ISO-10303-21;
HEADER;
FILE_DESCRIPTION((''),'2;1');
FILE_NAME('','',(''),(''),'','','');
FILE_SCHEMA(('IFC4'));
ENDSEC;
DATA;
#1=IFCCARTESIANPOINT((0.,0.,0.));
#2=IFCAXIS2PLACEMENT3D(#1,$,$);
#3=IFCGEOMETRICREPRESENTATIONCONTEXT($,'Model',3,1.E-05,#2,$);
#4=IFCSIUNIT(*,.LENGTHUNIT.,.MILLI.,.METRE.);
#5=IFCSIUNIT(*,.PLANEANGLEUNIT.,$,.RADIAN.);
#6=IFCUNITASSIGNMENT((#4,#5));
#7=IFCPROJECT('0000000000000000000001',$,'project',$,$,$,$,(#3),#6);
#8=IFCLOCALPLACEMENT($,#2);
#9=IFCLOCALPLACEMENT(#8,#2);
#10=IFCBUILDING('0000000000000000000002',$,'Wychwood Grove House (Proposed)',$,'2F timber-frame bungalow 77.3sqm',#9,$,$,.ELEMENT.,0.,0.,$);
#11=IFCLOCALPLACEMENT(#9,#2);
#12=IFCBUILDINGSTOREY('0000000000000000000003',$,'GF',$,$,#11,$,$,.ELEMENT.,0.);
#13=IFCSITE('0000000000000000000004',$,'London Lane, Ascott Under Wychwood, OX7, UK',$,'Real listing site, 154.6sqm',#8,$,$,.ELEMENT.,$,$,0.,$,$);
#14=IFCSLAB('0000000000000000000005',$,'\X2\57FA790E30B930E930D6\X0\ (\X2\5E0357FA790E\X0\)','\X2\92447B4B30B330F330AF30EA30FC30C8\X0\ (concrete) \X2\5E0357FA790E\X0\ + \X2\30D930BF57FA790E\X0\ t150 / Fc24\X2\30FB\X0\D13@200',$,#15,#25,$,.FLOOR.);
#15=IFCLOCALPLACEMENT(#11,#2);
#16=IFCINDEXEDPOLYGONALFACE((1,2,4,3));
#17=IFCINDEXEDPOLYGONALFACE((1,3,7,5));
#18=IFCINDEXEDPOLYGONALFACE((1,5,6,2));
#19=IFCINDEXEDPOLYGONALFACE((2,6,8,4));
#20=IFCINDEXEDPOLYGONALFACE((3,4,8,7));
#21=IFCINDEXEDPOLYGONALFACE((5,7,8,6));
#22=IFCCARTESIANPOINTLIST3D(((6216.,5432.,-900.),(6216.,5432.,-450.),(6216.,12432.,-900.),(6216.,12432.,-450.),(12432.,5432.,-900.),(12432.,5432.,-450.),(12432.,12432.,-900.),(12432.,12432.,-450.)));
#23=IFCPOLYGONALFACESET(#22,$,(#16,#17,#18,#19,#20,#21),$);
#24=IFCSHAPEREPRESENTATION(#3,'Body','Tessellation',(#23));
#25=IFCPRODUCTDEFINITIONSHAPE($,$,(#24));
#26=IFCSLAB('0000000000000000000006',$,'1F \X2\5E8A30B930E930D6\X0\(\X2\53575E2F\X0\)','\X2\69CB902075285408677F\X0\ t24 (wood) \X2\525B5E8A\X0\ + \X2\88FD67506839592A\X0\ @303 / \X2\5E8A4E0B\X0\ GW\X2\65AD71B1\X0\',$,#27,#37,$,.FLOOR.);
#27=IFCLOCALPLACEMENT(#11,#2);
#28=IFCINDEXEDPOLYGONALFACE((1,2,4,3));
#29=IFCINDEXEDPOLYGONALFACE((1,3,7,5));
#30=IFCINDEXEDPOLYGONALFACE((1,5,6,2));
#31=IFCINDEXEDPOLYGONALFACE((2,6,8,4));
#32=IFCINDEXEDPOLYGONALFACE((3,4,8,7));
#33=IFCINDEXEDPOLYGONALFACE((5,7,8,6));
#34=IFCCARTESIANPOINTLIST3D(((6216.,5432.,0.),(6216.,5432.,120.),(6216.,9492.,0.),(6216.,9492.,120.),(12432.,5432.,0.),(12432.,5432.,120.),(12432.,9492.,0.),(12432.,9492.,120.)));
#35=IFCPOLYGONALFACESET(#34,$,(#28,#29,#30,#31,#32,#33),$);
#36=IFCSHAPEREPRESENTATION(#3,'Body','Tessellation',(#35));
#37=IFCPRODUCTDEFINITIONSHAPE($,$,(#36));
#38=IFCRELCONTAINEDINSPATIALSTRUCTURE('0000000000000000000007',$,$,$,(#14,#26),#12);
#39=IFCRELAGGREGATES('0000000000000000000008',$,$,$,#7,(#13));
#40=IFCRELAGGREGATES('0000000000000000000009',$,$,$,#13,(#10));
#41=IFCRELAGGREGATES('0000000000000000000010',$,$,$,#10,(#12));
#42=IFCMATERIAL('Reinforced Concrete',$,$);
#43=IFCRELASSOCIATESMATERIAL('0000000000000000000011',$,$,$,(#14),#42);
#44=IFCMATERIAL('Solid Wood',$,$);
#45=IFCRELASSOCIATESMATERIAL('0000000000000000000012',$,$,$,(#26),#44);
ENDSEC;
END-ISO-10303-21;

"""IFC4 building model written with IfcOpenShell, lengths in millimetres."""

from ifc_helpers import new_model, si_unit, frame, frame_2d, origin, place, context, project, spatial, rectangle, extrude, material, element, save


model = new_model("IFC4")

# Units and contexts
model_context = context("Model", 3, precision=1e-05, world=origin())
ifc_project = project(units=[si_unit("LENGTHUNIT", "METRE", prefix="MILLI"), si_unit("PLANEANGLEUNIT", "RADIAN")], contexts=[model_context])

# Site, building, storey
site_placement = place(None, origin())
site = spatial("IfcSite", under=ifc_project, at=site_placement, Name="London Lane, Ascott Under Wychwood, OX7, UK", ObjectType="Real listing site, 154.6sqm", CompositionType="ELEMENT", RefElevation=0.0)
building_placement = place(site_placement, origin())
building = spatial("IfcBuilding", under=site, at=building_placement, Name="Wychwood Grove House (Proposed)", ObjectType="2F timber-frame bungalow 77.3sqm", CompositionType="ELEMENT", ElevationOfRefHeight=0.0, ElevationOfTerrain=0.0)
storey_placement = place(building_placement, origin())
storey = spatial("IfcBuildingStorey", under=building, at=storey_placement, Name="GF", CompositionType="ELEMENT", Elevation=0.0)

# Slabs
ifc_material_1 = material(Name="Reinforced Concrete")
slab_1_placement = place(storey_placement, frame((3108.0, 2716.0, -450.0)))
element("IfcSlab", 1, at=slab_1_placement, inside=storey, material=ifc_material_1, Name="基礎スラブ (布基礎)", Description="鉄筋コンクリート (concrete) 布基礎 + ベタ基礎 t150 / Fc24・D13@200", PredefinedType="FLOOR", context=model_context, shape_type="SweptSolid", body=[
    extrude(rectangle(XDim=6216.0, YDim=7000.0, at=frame_2d((3108.0, 3500.0))), frame((3108.0, 2716.0, -450.0)), (0.0, 0.0, 1.0), 450.0),
])
ifc_material_2 = material(Name="Solid Wood")
slab_2_placement = place(storey_placement, frame((3108.0, 2716.0, 0.0)))
element("IfcSlab", 2, at=slab_2_placement, inside=storey, material=ifc_material_2, Name="1F 床スラブ(南帯)", Description="構造用合板 t24 (wood) 剛床 + 製材根太 @303 / 床下 GW断熱", PredefinedType="FLOOR", context=model_context, shape_type="SweptSolid", body=[
    extrude(rectangle(XDim=6216.0, YDim=4060.0, at=frame_2d((3108.0, 2030.0))), frame((3108.0, 2716.0, 0.0)), (0.0, 0.0, 1.0), 120.0),
])

save(model, "model.ifc")
